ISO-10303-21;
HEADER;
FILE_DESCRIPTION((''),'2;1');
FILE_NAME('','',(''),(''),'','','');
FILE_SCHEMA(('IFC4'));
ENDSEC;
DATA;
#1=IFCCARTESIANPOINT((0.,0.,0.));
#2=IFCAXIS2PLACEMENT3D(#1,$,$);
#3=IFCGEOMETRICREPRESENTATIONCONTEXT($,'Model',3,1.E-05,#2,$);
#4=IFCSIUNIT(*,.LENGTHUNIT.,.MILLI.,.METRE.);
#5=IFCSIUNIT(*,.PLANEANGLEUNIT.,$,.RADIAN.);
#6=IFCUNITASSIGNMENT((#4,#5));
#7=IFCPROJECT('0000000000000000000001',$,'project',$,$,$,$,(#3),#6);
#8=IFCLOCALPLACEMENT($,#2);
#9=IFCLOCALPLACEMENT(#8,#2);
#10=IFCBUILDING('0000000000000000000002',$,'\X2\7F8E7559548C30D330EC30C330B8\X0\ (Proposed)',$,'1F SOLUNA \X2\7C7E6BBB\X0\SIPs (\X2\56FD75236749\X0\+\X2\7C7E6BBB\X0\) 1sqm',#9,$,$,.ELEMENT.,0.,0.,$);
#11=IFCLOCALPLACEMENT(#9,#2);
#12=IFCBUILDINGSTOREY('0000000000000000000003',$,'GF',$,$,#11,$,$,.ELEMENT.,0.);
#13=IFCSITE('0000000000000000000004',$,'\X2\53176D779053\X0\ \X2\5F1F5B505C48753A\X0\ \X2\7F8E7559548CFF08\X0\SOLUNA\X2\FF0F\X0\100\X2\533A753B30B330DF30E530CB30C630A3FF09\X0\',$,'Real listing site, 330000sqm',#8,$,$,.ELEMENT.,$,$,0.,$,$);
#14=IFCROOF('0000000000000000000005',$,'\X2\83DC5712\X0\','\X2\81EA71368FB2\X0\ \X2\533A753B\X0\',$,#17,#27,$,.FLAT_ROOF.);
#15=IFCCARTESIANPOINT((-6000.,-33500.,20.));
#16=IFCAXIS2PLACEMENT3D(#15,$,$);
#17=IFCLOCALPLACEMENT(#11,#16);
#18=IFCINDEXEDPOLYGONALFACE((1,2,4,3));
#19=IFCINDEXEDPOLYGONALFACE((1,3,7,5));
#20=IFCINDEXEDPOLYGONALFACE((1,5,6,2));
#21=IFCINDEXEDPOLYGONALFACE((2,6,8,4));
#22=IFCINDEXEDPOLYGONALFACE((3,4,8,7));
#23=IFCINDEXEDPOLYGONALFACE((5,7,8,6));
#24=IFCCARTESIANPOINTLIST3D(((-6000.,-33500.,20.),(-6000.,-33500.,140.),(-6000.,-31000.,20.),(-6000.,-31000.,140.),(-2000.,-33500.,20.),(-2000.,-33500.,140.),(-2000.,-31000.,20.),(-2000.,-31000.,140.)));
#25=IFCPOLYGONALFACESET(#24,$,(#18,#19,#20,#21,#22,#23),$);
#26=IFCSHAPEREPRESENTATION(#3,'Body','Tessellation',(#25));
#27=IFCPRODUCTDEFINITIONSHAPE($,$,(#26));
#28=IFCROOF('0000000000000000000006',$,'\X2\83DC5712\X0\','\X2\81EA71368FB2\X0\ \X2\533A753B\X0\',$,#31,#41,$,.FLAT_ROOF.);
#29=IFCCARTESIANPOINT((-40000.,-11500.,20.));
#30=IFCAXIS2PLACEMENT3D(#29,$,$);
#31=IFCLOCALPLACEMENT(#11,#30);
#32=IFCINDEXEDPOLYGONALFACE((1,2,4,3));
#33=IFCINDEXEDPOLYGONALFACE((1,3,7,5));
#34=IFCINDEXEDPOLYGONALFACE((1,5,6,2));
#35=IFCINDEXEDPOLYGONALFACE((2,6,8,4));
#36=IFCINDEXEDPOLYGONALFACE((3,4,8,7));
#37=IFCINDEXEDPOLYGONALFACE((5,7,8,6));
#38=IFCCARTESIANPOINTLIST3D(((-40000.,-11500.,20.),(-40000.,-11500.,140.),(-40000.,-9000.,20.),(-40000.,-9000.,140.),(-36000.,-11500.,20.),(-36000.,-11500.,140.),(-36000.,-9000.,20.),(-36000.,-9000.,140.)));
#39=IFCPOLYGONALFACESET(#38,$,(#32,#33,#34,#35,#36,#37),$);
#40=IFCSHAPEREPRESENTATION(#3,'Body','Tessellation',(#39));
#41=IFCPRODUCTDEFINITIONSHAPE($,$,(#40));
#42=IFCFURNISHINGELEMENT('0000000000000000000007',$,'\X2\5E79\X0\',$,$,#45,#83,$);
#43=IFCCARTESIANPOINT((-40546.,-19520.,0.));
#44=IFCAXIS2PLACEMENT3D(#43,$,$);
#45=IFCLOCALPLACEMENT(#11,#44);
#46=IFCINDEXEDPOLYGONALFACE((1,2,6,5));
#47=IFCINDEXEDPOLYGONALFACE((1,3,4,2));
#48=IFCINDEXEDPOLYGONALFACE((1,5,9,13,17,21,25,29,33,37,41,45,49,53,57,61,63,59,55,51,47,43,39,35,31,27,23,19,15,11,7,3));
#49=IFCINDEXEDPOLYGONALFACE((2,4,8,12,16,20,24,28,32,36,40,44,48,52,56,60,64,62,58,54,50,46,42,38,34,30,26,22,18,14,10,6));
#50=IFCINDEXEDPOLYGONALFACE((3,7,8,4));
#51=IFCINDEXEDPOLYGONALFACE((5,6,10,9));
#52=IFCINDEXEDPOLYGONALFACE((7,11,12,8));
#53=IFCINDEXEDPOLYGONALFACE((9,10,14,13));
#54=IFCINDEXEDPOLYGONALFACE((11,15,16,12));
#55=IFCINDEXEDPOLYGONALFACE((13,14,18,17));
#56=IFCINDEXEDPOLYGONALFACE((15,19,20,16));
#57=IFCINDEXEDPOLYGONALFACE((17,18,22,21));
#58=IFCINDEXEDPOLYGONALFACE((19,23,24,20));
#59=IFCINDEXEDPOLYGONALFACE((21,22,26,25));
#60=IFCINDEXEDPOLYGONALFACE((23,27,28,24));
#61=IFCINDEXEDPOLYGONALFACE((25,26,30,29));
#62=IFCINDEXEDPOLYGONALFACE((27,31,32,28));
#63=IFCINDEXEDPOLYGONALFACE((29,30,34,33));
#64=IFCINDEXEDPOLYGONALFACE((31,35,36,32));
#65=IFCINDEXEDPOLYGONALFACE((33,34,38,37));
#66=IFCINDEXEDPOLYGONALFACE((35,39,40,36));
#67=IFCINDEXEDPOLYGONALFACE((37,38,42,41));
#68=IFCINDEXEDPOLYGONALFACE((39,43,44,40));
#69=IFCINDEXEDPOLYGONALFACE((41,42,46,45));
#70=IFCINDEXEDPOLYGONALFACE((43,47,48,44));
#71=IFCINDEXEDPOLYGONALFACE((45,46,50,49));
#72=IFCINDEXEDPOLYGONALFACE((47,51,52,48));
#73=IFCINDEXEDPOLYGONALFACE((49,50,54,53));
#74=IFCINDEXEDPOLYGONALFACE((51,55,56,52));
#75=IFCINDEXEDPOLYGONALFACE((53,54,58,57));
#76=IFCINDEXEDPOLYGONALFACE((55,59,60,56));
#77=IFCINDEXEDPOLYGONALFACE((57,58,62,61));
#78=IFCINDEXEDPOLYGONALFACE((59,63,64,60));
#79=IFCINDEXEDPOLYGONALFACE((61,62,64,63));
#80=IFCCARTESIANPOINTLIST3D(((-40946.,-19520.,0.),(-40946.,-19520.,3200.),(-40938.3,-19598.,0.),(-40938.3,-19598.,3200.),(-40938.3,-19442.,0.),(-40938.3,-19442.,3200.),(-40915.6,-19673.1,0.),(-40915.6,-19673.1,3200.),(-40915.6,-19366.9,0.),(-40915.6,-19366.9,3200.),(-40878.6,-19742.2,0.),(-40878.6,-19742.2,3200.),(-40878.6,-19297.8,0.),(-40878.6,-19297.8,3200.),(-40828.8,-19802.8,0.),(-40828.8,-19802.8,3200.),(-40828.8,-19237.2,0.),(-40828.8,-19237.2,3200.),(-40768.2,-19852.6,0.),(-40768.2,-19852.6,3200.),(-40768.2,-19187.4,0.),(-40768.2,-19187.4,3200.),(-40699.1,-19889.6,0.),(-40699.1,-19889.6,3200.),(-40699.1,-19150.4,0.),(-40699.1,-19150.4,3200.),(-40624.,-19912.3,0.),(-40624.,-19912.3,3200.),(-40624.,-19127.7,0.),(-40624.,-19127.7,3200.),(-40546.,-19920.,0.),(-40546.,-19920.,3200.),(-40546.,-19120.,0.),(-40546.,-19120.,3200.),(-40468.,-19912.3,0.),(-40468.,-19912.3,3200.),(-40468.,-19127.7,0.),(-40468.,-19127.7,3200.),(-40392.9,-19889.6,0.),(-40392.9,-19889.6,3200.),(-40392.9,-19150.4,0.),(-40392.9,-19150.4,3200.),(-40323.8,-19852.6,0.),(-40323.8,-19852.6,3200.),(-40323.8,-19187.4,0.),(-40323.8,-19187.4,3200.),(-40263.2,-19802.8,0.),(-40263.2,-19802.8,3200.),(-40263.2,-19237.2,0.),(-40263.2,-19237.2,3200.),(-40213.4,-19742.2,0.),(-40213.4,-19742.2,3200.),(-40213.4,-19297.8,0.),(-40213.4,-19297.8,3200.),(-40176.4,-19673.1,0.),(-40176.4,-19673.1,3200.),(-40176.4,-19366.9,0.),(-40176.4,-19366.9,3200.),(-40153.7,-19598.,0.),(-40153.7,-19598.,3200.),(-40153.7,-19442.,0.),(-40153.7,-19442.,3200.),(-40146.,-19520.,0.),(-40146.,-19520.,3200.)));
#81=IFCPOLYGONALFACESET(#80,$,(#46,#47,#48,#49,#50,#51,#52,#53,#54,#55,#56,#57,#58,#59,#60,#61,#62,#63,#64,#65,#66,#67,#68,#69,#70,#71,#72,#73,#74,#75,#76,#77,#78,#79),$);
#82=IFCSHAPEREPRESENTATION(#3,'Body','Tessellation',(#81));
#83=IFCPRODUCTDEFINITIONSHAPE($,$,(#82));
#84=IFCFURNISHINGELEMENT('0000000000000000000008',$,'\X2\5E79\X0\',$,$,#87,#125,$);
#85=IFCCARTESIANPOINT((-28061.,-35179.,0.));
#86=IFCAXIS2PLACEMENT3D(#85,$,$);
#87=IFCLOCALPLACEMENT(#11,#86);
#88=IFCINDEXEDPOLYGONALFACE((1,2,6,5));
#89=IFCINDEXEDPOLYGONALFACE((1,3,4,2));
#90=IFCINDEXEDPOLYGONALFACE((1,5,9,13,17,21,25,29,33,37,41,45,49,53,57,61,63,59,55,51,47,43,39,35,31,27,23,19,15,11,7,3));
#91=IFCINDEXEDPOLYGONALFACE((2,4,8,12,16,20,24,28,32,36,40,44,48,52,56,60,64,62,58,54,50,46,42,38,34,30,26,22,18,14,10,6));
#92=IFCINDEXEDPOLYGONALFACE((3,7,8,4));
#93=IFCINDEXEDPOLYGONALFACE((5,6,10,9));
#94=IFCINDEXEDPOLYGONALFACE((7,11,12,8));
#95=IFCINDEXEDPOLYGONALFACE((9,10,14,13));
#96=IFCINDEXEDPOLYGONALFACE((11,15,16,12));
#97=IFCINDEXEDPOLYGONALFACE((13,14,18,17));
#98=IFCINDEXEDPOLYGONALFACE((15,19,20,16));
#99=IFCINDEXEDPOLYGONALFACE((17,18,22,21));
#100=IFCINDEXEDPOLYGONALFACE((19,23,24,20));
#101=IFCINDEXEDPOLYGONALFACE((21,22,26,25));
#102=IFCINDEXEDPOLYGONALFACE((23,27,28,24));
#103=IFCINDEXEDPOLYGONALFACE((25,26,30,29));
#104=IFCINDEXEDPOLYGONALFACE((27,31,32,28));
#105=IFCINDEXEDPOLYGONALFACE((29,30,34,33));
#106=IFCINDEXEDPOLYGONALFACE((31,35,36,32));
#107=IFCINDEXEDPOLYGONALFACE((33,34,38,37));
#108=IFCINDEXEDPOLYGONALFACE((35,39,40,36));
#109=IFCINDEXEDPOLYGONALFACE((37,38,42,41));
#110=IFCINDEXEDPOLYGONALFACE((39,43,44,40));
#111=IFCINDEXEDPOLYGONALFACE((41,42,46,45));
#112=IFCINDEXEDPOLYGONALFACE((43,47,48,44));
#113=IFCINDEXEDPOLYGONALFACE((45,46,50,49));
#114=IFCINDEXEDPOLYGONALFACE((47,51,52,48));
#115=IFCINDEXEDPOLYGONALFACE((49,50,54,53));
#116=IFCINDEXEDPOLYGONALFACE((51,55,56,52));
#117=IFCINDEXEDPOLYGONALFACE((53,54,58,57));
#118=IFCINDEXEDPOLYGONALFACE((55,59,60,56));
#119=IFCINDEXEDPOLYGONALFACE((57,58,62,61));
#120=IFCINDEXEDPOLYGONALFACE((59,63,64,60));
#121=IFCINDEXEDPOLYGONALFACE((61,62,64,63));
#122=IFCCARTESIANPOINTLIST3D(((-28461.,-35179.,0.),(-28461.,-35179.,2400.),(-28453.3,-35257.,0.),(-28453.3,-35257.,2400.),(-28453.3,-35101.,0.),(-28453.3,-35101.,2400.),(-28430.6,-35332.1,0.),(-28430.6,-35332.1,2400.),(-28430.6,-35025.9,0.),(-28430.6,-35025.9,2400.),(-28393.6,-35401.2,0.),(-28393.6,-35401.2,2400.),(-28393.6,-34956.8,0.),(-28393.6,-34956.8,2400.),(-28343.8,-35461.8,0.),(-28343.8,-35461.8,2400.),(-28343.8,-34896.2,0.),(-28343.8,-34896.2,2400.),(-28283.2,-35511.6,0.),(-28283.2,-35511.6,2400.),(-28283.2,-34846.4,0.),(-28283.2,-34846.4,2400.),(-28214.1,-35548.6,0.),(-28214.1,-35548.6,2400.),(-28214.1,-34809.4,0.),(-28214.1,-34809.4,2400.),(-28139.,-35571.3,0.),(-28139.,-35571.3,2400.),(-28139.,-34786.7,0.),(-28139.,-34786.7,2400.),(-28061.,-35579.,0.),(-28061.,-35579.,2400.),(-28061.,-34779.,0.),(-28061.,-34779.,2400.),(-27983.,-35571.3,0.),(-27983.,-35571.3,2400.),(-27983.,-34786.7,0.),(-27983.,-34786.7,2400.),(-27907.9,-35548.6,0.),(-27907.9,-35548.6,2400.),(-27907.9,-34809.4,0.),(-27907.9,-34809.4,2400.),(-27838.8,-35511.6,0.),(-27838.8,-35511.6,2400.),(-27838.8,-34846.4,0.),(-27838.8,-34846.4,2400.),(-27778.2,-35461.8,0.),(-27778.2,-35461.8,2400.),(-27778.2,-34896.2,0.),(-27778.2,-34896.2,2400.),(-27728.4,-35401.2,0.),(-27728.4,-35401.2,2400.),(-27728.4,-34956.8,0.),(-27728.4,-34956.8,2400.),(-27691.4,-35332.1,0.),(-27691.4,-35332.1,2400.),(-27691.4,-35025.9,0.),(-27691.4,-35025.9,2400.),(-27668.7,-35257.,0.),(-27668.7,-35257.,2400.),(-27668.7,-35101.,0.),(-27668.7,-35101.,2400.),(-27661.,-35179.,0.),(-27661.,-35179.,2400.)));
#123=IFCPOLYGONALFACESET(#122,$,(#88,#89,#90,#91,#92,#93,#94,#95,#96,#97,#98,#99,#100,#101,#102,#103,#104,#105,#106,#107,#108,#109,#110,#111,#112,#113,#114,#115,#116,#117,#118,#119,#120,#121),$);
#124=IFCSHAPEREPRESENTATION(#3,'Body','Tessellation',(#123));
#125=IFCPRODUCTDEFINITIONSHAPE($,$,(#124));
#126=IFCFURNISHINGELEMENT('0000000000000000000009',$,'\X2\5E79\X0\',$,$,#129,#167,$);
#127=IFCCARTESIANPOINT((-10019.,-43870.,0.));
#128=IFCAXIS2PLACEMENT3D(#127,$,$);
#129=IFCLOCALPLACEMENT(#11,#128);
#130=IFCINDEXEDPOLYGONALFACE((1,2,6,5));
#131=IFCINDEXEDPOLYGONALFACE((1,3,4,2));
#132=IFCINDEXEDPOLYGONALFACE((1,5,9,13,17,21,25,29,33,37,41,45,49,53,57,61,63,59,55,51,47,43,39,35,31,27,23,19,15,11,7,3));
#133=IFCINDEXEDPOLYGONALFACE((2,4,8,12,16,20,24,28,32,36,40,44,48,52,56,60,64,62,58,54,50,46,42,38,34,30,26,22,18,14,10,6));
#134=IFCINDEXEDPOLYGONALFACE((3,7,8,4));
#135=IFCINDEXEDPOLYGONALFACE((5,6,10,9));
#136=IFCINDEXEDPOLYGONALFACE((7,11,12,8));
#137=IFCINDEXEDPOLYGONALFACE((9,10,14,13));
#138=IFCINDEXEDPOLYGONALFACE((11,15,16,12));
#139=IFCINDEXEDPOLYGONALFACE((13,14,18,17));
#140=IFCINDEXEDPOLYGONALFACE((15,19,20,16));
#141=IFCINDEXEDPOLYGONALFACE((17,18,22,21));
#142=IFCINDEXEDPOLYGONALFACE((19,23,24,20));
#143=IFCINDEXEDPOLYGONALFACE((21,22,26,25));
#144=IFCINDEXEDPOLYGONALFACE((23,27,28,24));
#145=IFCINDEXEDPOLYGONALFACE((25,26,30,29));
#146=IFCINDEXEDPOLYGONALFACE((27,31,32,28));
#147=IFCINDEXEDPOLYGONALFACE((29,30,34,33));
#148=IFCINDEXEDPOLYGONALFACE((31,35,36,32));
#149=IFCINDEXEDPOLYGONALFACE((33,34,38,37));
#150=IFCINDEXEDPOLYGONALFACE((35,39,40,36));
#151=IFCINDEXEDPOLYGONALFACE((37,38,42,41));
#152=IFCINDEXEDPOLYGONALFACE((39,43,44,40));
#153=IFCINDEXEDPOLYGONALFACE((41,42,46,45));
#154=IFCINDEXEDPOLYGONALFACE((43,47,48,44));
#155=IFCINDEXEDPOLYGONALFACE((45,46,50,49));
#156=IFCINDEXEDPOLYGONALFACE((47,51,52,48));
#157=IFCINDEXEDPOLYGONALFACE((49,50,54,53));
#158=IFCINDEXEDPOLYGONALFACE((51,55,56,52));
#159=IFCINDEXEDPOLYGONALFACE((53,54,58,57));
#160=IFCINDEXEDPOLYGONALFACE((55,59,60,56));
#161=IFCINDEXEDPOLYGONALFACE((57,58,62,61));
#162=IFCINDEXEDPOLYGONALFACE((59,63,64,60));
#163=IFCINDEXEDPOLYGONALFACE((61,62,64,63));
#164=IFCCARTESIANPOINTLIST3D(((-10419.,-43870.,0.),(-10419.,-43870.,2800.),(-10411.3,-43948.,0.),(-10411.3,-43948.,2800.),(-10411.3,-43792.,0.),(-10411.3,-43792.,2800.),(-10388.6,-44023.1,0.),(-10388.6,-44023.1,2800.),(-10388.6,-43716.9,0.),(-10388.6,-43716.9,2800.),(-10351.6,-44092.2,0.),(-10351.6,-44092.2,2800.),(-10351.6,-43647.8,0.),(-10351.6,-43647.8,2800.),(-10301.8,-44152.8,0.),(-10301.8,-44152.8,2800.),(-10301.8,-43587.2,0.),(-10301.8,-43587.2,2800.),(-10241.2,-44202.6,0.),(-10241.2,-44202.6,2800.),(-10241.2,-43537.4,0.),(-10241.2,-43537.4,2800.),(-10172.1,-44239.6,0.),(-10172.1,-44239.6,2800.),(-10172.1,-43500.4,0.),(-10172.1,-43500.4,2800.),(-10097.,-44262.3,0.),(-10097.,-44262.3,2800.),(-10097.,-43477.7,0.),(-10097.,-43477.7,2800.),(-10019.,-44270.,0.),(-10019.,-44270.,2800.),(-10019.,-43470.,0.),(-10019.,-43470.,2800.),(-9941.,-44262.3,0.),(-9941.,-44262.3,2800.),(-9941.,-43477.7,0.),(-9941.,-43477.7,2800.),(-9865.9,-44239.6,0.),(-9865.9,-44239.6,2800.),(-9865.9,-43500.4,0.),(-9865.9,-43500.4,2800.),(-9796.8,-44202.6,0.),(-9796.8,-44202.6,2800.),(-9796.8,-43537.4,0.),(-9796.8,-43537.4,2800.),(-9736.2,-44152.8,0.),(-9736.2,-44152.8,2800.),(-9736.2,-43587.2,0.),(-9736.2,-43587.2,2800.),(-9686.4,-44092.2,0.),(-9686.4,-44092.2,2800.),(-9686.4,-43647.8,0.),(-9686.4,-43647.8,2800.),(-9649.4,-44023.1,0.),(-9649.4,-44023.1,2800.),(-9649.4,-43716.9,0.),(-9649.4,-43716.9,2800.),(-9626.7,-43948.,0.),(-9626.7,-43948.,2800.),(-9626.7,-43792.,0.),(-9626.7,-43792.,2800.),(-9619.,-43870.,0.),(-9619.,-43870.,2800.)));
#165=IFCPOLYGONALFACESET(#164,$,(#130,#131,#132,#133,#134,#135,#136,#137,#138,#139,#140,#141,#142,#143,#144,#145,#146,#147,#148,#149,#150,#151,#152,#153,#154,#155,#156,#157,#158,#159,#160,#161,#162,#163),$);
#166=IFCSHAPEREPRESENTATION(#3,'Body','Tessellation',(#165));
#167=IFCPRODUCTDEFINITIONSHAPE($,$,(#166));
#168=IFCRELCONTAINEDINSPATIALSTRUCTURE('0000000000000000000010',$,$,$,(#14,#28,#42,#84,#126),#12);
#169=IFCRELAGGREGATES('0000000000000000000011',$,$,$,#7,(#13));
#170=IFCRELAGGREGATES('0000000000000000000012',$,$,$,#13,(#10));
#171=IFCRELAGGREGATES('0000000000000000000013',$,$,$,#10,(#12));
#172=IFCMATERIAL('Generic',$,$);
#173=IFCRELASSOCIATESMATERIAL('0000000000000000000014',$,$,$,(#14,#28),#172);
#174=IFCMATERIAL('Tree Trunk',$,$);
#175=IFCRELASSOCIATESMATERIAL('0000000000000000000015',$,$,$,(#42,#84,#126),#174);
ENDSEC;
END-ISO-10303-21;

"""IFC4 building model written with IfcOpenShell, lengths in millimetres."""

from ifc_helpers import new_model, si_unit, frame, frame_2d, origin, origin_2d, place, context, project, spatial, rectangle, circle, extrude, material, element, save


model = new_model("IFC4")

# Units and contexts
model_context = context("Model", 3, precision=1e-05, world=origin())
ifc_project = project(units=[si_unit("LENGTHUNIT", "METRE", prefix="MILLI"), si_unit("PLANEANGLEUNIT", "RADIAN")], contexts=[model_context])

# Site, building, storey
site_placement = place(None, origin())
site = spatial("IfcSite", under=ifc_project, at=site_placement, Name="北海道 弟子屈町 美留和（SOLUNA／100区画コミュニティ）", ObjectType="Real listing site, 330000sqm", CompositionType="ELEMENT", RefElevation=0.0)
building_placement = place(site_placement, origin())
building = spatial("IfcBuilding", under=site, at=building_placement, Name="美留和ビレッジ (Proposed)", ObjectType="1F SOLUNA 籾殻SIPs (国産杉+籾殻) 1sqm", CompositionType="ELEMENT", ElevationOfRefHeight=0.0, ElevationOfTerrain=0.0)
storey_placement = place(building_placement, origin())
storey = spatial("IfcBuildingStorey", under=building, at=storey_placement, Name="GF", CompositionType="ELEMENT", Elevation=0.0)

# Shared definitions
ifc_material_1 = material(Name="Generic")

# Roofs
roof_1_placement = place(storey_placement, frame((-6000.0, -33500.0, 20.0)))
element("IfcRoof", 1, at=roof_1_placement, inside=storey, material=ifc_material_1, Name="菜園", Description="自然農 区画", PredefinedType="FLAT_ROOF", context=model_context, shape_type="SweptSolid", body=[
    extrude(rectangle(XDim=4000.0, YDim=2500.0, at=frame_2d((2000.0, 1250.0))), frame((-6000.0, -33500.0, 20.0)), (0.0, 0.0, 1.0), 120.0),
])
roof_2_placement = place(storey_placement, frame((-40000.0, -11500.0, 20.0)))
element("IfcRoof", 2, at=roof_2_placement, inside=storey, material=ifc_material_1, Name="菜園", Description="自然農 区画", PredefinedType="FLAT_ROOF", context=model_context, shape_type="SweptSolid", body=[
    extrude(rectangle(XDim=4000.0, YDim=2500.0, at=frame_2d((2000.0, 1250.0))), frame((-40000.0, -11500.0, 20.0)), (0.0, 0.0, 1.0), 120.0),
])

# Furnishing elements
ifc_material_2 = material(Name="Tree Trunk")
furnishing_1_placement = place(storey_placement, frame((-40546.0, -19520.0, 0.0)))
element("IfcFurnishingElement", 3, at=furnishing_1_placement, inside=storey, material=ifc_material_2, Name="幹", context=model_context, shape_type="SweptSolid", body=[
    extrude(circle(Radius=400.0, at=origin_2d()), frame((-40546.0, -19520.0, 0.0)), (0.0, 0.0, 1.0), 3200.0),
])
furnishing_2_placement = place(storey_placement, frame((-28061.0, -35179.0, 0.0)))
element("IfcFurnishingElement", 4, at=furnishing_2_placement, inside=storey, material=ifc_material_2, Name="幹", context=model_context, shape_type="SweptSolid", body=[
    extrude(circle(Radius=400.0, at=origin_2d()), frame((-28061.0, -35179.0, 0.0)), (0.0, 0.0, 1.0), 2400.0),
])
furnishing_3_placement = place(storey_placement, frame((-10019.0, -43870.0, 0.0)))
element("IfcFurnishingElement", 5, at=furnishing_3_placement, inside=storey, material=ifc_material_2, Name="幹", context=model_context, shape_type="SweptSolid", body=[
    extrude(circle(Radius=400.0, at=origin_2d()), frame((-10019.0, -43870.0, 0.0)), (0.0, 0.0, 1.0), 2800.0),
])

save(model, "model.ifc")
